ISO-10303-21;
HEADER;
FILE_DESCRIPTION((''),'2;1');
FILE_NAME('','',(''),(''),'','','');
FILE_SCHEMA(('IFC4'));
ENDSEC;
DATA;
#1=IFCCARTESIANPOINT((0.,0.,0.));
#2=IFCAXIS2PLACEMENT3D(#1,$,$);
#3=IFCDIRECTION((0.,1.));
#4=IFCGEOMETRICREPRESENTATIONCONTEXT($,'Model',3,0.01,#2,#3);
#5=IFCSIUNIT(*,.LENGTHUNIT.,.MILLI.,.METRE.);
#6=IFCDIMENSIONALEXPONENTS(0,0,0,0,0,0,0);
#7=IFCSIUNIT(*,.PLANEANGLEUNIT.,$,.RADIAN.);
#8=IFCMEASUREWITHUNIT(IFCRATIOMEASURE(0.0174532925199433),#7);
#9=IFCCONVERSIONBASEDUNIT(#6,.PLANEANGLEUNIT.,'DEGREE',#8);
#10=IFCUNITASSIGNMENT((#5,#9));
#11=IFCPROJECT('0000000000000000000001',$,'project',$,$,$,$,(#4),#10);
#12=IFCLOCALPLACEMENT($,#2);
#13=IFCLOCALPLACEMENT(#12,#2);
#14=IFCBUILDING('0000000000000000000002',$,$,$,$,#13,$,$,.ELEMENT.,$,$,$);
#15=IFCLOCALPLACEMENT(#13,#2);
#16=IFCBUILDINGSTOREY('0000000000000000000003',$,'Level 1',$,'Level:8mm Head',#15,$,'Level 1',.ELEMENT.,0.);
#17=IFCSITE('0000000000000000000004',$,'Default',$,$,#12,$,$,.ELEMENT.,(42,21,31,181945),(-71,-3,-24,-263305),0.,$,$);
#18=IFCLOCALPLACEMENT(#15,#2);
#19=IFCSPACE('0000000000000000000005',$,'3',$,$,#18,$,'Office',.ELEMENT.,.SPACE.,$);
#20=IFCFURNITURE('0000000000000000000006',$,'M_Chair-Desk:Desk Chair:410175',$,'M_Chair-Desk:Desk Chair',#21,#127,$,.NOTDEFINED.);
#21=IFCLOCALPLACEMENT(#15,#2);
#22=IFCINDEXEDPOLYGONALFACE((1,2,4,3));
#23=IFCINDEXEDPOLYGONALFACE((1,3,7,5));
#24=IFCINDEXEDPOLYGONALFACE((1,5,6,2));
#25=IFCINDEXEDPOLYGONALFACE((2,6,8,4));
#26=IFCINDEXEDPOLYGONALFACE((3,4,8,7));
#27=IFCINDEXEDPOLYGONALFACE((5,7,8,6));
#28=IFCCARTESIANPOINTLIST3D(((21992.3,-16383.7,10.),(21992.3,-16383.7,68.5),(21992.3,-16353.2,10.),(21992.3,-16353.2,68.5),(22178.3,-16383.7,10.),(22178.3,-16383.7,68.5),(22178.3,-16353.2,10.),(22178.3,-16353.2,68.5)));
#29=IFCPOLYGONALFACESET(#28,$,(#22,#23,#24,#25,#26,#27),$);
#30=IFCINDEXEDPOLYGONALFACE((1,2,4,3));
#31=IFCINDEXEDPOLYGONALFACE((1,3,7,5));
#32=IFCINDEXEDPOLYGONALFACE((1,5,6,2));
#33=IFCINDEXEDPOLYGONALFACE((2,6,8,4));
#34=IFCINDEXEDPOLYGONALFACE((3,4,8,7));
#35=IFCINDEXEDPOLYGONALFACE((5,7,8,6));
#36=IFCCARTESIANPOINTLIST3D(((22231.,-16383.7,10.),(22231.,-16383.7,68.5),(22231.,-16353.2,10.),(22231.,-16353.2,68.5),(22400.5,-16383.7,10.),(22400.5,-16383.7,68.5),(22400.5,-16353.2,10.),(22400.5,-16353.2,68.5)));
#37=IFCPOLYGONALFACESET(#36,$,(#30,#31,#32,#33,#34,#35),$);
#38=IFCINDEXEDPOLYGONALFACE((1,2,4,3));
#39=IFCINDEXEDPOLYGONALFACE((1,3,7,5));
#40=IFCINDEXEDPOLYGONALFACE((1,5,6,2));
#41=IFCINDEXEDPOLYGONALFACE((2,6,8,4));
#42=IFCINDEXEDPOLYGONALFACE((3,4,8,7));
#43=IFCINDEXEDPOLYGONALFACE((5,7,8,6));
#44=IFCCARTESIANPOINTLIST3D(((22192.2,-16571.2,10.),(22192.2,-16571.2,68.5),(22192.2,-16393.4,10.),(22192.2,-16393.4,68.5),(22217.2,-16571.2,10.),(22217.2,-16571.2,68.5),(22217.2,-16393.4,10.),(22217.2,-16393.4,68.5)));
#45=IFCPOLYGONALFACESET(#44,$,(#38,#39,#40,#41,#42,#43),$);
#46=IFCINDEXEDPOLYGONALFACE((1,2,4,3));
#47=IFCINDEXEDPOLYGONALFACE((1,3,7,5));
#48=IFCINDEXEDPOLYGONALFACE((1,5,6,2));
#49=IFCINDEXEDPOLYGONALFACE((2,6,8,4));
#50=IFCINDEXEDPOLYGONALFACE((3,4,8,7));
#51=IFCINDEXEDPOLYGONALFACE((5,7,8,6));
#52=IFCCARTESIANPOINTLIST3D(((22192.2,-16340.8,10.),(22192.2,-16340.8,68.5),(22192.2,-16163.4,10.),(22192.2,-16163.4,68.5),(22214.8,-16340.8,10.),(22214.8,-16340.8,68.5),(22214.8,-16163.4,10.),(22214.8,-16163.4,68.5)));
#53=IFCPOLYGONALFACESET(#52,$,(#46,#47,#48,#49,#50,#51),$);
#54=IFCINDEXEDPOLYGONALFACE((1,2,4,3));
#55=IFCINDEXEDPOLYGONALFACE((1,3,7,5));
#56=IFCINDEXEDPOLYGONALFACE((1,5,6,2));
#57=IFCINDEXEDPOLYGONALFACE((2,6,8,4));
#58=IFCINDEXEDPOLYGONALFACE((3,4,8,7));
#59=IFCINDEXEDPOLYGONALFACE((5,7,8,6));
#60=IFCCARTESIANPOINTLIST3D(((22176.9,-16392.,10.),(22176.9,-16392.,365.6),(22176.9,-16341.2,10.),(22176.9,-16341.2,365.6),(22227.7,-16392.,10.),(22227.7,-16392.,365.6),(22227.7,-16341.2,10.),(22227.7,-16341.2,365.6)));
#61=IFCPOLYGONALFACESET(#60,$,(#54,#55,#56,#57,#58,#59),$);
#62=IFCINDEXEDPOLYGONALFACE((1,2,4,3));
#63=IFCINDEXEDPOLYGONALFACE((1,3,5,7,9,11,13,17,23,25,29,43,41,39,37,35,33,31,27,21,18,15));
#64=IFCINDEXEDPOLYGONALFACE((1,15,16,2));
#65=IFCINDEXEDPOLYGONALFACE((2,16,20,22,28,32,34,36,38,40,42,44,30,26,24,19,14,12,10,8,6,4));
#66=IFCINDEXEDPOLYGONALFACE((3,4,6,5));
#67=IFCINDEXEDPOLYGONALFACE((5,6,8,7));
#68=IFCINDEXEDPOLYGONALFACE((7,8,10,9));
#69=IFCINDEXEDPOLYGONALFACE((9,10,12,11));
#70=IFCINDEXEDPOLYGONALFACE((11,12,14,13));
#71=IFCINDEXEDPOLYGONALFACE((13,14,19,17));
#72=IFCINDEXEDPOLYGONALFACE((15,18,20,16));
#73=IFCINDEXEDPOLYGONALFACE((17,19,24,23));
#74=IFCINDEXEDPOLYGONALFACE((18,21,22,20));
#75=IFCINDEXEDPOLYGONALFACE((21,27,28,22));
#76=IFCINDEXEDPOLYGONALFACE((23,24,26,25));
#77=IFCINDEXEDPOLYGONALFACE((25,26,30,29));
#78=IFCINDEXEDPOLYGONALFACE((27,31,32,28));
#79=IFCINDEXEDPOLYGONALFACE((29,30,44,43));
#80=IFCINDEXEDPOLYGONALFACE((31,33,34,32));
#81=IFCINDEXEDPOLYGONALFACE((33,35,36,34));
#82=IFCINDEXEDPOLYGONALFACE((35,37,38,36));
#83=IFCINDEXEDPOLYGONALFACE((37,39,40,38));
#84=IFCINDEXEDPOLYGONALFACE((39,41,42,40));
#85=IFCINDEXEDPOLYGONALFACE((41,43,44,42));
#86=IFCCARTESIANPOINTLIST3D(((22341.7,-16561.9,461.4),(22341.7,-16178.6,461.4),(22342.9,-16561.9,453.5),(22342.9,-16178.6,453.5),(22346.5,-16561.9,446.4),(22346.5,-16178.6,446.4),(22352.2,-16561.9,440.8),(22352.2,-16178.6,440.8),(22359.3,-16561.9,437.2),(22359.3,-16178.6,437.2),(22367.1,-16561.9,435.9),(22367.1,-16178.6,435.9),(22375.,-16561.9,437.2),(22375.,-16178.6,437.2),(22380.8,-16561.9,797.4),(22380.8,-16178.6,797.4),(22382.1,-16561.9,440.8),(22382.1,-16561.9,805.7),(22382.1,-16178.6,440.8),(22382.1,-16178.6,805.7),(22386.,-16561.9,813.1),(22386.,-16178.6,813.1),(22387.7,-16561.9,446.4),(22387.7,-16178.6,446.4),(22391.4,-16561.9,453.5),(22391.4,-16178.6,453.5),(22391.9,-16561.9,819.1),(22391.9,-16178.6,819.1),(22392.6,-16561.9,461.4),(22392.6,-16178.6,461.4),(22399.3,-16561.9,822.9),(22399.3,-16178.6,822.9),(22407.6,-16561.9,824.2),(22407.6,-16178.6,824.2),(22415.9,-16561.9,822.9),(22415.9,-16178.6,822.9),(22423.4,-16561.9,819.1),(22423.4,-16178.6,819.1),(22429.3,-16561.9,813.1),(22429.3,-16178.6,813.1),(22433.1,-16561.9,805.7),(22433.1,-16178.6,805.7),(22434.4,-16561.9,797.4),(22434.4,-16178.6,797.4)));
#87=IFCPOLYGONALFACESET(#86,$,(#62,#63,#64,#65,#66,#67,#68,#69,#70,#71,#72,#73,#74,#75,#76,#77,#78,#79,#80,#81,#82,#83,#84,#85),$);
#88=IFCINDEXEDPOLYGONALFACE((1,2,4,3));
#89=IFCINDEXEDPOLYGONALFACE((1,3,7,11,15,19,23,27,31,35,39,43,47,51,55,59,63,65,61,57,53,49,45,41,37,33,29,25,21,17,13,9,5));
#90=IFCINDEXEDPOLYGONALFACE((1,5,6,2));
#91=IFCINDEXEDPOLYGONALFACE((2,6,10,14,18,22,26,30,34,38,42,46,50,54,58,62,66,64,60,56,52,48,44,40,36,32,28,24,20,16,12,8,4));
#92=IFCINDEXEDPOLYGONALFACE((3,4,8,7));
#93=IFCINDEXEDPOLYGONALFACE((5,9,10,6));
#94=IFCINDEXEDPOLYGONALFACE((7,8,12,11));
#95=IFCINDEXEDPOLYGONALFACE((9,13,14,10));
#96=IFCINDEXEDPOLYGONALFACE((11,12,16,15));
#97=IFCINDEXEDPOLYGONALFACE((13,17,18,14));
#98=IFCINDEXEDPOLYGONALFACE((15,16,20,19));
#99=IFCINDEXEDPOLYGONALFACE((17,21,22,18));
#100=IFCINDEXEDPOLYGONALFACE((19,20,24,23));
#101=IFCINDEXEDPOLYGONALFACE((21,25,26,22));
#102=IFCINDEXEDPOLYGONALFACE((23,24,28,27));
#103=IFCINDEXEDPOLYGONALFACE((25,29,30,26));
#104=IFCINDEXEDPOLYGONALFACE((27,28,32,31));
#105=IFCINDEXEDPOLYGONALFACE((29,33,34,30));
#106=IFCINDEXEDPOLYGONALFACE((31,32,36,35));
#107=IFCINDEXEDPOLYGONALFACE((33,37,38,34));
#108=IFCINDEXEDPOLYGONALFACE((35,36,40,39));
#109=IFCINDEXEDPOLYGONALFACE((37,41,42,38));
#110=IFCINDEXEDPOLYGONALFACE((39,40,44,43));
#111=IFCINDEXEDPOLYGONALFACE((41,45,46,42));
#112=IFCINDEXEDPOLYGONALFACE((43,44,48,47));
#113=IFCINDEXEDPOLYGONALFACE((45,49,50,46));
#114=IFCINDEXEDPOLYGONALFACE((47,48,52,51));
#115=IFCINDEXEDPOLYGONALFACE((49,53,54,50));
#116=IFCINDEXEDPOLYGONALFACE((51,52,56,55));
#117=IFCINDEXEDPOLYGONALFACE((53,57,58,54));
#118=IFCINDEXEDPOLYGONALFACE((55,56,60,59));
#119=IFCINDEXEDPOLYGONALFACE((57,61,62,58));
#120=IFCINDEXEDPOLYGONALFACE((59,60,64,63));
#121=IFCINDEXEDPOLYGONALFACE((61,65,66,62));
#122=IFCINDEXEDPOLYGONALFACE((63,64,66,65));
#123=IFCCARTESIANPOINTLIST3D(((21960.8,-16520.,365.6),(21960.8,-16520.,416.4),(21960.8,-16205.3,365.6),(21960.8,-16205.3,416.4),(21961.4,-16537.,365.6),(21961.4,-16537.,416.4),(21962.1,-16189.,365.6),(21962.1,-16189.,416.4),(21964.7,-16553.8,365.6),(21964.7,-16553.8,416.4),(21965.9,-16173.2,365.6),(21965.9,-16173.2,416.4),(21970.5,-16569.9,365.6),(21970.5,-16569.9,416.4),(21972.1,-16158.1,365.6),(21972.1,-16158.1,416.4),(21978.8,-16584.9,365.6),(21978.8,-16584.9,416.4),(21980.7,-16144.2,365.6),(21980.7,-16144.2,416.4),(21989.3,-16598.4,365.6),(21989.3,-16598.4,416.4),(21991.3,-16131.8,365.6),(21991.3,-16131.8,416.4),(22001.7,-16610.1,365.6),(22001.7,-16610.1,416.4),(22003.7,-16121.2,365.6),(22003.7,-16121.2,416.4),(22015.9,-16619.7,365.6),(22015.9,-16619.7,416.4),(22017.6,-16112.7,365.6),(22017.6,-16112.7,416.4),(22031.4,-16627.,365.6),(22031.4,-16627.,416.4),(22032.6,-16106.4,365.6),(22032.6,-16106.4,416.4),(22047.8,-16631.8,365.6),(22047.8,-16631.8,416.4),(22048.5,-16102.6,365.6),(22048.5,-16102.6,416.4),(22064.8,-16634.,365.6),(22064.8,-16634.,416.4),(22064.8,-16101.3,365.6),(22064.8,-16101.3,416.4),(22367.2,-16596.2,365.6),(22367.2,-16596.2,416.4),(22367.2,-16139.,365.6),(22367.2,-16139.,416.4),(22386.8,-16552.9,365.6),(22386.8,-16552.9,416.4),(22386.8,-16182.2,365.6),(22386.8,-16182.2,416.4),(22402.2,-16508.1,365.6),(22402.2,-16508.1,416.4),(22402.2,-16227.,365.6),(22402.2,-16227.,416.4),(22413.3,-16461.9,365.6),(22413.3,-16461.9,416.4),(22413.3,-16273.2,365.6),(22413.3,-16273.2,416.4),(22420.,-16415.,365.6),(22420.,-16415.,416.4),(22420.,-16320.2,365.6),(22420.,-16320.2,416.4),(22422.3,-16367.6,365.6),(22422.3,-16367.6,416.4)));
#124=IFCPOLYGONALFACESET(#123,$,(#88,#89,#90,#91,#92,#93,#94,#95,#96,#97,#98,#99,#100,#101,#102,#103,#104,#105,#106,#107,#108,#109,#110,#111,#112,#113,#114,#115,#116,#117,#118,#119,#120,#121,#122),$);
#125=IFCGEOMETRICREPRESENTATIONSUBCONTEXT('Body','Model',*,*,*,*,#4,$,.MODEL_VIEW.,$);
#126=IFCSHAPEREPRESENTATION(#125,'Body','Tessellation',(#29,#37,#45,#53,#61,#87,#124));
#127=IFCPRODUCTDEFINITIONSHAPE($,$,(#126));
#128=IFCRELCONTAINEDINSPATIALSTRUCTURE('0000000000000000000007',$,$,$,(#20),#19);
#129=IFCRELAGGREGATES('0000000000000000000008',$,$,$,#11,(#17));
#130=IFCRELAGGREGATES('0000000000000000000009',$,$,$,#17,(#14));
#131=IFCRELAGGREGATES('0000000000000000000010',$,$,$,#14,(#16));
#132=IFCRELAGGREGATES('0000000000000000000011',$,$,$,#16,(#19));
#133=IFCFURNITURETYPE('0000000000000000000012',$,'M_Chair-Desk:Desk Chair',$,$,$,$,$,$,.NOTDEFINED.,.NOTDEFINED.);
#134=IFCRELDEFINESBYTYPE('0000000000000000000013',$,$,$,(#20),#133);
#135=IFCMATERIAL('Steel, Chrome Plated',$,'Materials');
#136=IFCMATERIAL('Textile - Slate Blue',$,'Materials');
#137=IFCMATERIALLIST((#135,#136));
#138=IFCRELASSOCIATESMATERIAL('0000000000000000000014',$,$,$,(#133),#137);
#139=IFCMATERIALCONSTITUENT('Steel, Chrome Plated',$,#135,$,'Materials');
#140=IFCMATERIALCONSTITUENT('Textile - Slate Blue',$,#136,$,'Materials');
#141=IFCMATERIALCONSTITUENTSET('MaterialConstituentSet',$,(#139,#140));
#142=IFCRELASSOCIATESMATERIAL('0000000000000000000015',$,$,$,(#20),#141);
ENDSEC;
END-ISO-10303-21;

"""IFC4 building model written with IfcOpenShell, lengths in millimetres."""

from ifc_helpers import new_model, entity, si_unit, converted_unit, direction, frame, origin, place, context, subcontext, project, spatial, indexed_curve, outline, extrude, source, transform, mapped, material, material_list, constituent, constituent_set, type_object, type_shapes, element, save


model = new_model("IFC4")

# Units and contexts
model_context = context("Model", 3, precision=0.01, world=origin(), true_north=direction((0.0, 1.0)))
body_context = subcontext(model_context, "Body", "Model", "MODEL_VIEW")
ifc_project = project(units=[si_unit("LENGTHUNIT", "METRE", prefix="MILLI"), converted_unit("PLANEANGLEUNIT", "DEGREE", entity("IfcRatioMeasure", 0.0174532925199433), si_unit("PLANEANGLEUNIT", "RADIAN"), dimensions=[0, 0, 0, 0, 0, 0, 0])], contexts=[model_context])

# Site, building, storey
site_placement = place(None, origin())
site = spatial("IfcSite", under=ifc_project, at=site_placement, Name="Default", CompositionType="ELEMENT", RefLatitude=(42, 21, 31, 181945), RefLongitude=(-71, -3, -24, -263305), RefElevation=0.0)
building_placement = place(site_placement, origin())
building = spatial("IfcBuilding", under=site, at=building_placement, CompositionType="ELEMENT")
storey_placement = place(building_placement, origin())
storey = spatial("IfcBuildingStorey", under=building, at=storey_placement, Name="Level 1", ObjectType="Level:8mm Head", LongName="Level 1", CompositionType="ELEMENT", Elevation=0.0)

# Shared definitions
space_placement = place(storey_placement, origin())
space = spatial("IfcSpace", under=storey, at=space_placement, Name="3", LongName="Office", CompositionType="ELEMENT", PredefinedType="SPACE")

# Furniture
ifc_material_1 = material(Name="Steel, Chrome Plated", Category="Materials")
ifc_material_2 = material(Name="Textile - Slate Blue", Category="Materials")
ifc_material_list_1 = material_list([ifc_material_1, ifc_material_2])
furniture_type = type_object("IfcFurnitureType", Name="M_Chair-Desk:Desk Chair", AssemblyPlace="NOTDEFINED", PredefinedType="NOTDEFINED", material=ifc_material_list_1)
shared_shape_1 = source(origin(), body_context, "Body", "SweptSolid", [
    extrude(outline(indexed_curve([(-15.2, -93.0), (15.2, -93.0), (15.2, 93.0), (-15.2, 93.0), (-15.2, -93.0)], self_intersect=False)), frame((-0.9, 281.9, 0.0)), (0.0, 0.0, 1.0), 58.5),
    extrude(outline(indexed_curve([(-15.2, -84.7), (15.2, -84.7), (15.2, 84.7), (-15.2, 84.7), (-15.2, -84.7)], self_intersect=False)), frame((-0.9, 51.5, 0.0), z_axis=(0.0, 0.0, 1.0), x_axis=(-1.0, 0.0, 0.0)), (0.0, 0.0, 1.0), 58.5),
    extrude(outline(indexed_curve([(-12.5, -88.9), (12.5, -88.9), (12.5, 88.9), (-12.5, 88.9), (-12.5, -88.9)], self_intersect=False)), frame((-114.8, 162.5, 0.0), z_axis=(0.0, 0.0, 1.0), x_axis=(0.0, -1.0, 0.0)), (0.0, 0.0, 1.0), 58.5),
    extrude(outline(indexed_curve([(-88.7, -11.3), (88.7, -11.3), (88.7, 11.3), (-88.7, 11.3), (-88.7, -11.3)], self_intersect=False)), frame((115.5, 163.7, 0.0), z_axis=(0.0, 0.0, 1.0), x_axis=(-1.0, 0.0, 0.0)), (0.0, 0.0, 1.0), 58.5),
    extrude(outline(indexed_curve([(-25.4, -25.4), (25.4, -25.4), (25.4, 25.4), (-25.4, 25.4), (-25.4, -25.4)], self_intersect=False)), frame((0.9, 164.9, 0.0), z_axis=(0.0, 0.0, 1.0), x_axis=(-1.0, 0.0, 0.0)), (0.0, 0.0, 1.0), 355.6),
    extrude(outline(indexed_curve([(6.5, 168.0), (5.2, 176.3), (1.4, 183.8), (-4.5, 189.7), (-12.0, 193.5), (-20.2, 194.8), (-28.5, 193.5), (-36.0, 189.7), (-41.9, 183.8), (-45.7, 176.3), (-47.0, 168.0), (-5.2, -168.0), (-4.0, -175.9), (-0.4, -183.0), (5.3, -188.6), (12.4, -192.2), (20.2, -193.5), (28.1, -192.2), (35.2, -188.6), (40.9, -183.0), (44.5, -175.9), (45.7, -168.0), (6.5, 168.0)], self_intersect=False)), frame((-194.4, -20.2, 619.4), z_axis=(1.0, 0.0, 0.0), x_axis=(0.0, 1.0, 0.0)), (0.0, 0.0, 1.0), 383.3),
    extrude(outline(indexed_curve([(-98.9, -257.7), (205.9, -257.7), (230.7, -217.3), (251.6, -174.7), (268.3, -130.3), (280.8, -84.5), (288.9, -37.7), (292.6, 9.6), (291.7, 57.0), (286.4, 104.2), (276.7, 150.6), (262.6, 195.9), (-32.8, 270.8), (-49.1, 271.5), (-65.3, 269.7), (-81.1, 265.4), (-95.9, 258.6), (-109.5, 249.7), (-121.6, 238.7), (-131.8, 225.9), (-139.8, 211.7), (-145.6, 196.5), (-148.9, 180.5), (-187.9, -131.7), (-189.4, -148.8), (-188.3, -165.8), (-184.5, -182.5), (-178.1, -198.4), (-169.4, -213.1), (-158.5, -226.2), (-145.6, -237.5), (-131.2, -246.7), (-115.5, -253.5), (-98.9, -257.7)], self_intersect=False)), frame((1.6, 236.3, 355.6), z_axis=(0.0, 0.0, 1.0), x_axis=(0.124035, -0.992278, 0.0)), (0.0, 0.0, 1.0), 50.8),
])
type_shapes(furniture_type, [shared_shape_1])
ifc_constituent_1 = constituent(ifc_material_1, Name="Steel, Chrome Plated", Category="Materials")
ifc_constituent_2 = constituent(ifc_material_2, Name="Textile - Slate Blue", Category="Materials")
ifc_constituent_set_1 = constituent_set(constituents=[ifc_constituent_1, ifc_constituent_2], Name="MaterialConstituentSet")
furniture_1_placement = place(space_placement, frame((22367.2, -16367.6, 10.0), z_axis=(0.0, 0.0, 1.0), x_axis=(0.0, 1.0, 0.0)))
element("IfcFurniture", 1, at=furniture_1_placement, inside=space, type_object=furniture_type, material=ifc_constituent_set_1, Name="M_Chair-Desk:Desk Chair:410175", ObjectType="M_Chair-Desk:Desk Chair", PredefinedType="NOTDEFINED", context=body_context, shape_type="MappedRepresentation", body=[
    mapped(shared_shape_1, transform((0.0, 0.0, 0.0), scale=1.0)),
])

save(model, "model.ifc")
